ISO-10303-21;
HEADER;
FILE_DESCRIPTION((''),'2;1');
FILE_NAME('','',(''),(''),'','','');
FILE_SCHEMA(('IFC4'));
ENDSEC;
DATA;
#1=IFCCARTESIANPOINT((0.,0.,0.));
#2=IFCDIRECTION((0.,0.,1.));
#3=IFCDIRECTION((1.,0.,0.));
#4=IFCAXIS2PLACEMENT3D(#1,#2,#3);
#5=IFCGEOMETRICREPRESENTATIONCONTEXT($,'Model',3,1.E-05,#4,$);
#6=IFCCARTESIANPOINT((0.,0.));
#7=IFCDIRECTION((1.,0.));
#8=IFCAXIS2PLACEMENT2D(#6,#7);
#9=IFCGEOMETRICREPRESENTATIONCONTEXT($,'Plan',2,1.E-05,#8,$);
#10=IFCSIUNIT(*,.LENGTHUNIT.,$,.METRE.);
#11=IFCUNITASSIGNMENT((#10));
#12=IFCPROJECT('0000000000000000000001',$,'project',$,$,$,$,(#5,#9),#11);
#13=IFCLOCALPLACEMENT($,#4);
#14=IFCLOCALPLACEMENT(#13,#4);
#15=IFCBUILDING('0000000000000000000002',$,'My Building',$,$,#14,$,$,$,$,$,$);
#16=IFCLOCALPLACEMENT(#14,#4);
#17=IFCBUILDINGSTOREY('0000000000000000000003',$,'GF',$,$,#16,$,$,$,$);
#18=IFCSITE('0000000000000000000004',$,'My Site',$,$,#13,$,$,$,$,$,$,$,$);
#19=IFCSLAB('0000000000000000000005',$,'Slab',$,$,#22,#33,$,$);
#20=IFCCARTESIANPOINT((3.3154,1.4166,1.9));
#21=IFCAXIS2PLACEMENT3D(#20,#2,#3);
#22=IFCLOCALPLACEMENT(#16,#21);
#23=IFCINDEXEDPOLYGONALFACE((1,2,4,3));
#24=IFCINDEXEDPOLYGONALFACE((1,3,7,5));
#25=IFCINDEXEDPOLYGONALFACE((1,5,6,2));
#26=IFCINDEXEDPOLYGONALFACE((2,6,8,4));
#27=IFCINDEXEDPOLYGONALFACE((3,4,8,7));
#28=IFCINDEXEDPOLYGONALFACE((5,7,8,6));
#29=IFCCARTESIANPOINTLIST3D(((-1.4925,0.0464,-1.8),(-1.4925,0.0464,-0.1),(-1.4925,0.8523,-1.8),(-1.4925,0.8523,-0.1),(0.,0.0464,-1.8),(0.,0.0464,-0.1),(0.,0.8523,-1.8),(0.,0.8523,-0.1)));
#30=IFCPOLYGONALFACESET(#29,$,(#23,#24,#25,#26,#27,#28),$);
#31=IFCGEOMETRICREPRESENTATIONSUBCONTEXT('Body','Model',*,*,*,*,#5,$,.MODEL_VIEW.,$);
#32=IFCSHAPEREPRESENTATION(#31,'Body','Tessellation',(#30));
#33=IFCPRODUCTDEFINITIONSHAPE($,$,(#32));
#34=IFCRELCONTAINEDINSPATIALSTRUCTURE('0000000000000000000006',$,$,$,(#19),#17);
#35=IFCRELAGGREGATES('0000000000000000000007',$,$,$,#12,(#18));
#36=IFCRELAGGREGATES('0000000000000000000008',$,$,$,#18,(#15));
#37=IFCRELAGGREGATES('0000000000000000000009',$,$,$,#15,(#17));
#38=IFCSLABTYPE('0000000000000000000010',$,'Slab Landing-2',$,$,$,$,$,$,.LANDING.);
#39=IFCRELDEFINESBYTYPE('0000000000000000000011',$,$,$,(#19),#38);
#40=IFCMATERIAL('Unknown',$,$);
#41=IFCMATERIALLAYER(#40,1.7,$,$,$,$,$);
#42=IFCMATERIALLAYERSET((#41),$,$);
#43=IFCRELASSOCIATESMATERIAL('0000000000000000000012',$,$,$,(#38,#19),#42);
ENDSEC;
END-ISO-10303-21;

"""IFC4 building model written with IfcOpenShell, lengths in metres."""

from ifc_helpers import new_model, si_unit, frame, origin_with_axes, origin_2d_with_axis, place, context, subcontext, project, spatial, indexed_curve, outline, extrude, material, layer, layer_set, layer_usage, type_object, element, save


model = new_model("IFC4")

# Units and contexts
model_context = context("Model", 3, precision=1e-05, world=origin_with_axes())
plan_context = context("Plan", 2, precision=1e-05, world=origin_2d_with_axis())
body_context_1 = subcontext(model_context, "Body", "Model", "MODEL_VIEW")
ifc_project = project(units=[si_unit("LENGTHUNIT", "METRE")], contexts=[model_context, plan_context])

# Site, building, storey
site_placement = place(None, origin_with_axes())
site = spatial("IfcSite", under=ifc_project, at=site_placement, Name="My Site")
building_placement = place(site_placement, origin_with_axes())
building = spatial("IfcBuilding", under=site, at=building_placement, Name="My Building")
storey_placement = place(building_placement, origin_with_axes())
storey = spatial("IfcBuildingStorey", under=building, at=storey_placement, Name="GF")

# Shared definitions
ifc_material = material(Name="Unknown")

# Slab
ifc_layer_1 = layer(ifc_material, 1.7)
ifc_layer_set_1 = layer_set([ifc_layer_1])
ifc_layer_usage_1 = layer_usage(ifc_layer_set_1, "AXIS3", "POSITIVE", -1.8)
slab_type_1 = type_object("IfcSlabType", Name="Slab Landing-2", PredefinedType="LANDING", material=ifc_layer_set_1)
slab_1_placement = place(storey_placement, frame((3.3154, 1.4166, 1.9), z_axis=(0.0, 0.0, 1.0), x_axis=(1.0, 0.0, 0.0)))
element("IfcSlab", 1, at=slab_1_placement, inside=storey, type_object=slab_type_1, material=ifc_layer_usage_1, Name="Slab", context=body_context_1, shape_type="SweptSolid", body=[
    extrude(outline(indexed_curve([(0.0, 0.8523), (-1.4925, 0.8523), (-1.4925, 0.0464), (0.0, 0.0464), (0.0, 0.8523)])), frame((0.0, 0.0, -1.8), z_axis=(0.0, 0.0, 1.0), x_axis=(1.0, 0.0, 0.0)), (0.0, 0.0, 1.0), 1.7),
])

save(model, "model.ifc")
